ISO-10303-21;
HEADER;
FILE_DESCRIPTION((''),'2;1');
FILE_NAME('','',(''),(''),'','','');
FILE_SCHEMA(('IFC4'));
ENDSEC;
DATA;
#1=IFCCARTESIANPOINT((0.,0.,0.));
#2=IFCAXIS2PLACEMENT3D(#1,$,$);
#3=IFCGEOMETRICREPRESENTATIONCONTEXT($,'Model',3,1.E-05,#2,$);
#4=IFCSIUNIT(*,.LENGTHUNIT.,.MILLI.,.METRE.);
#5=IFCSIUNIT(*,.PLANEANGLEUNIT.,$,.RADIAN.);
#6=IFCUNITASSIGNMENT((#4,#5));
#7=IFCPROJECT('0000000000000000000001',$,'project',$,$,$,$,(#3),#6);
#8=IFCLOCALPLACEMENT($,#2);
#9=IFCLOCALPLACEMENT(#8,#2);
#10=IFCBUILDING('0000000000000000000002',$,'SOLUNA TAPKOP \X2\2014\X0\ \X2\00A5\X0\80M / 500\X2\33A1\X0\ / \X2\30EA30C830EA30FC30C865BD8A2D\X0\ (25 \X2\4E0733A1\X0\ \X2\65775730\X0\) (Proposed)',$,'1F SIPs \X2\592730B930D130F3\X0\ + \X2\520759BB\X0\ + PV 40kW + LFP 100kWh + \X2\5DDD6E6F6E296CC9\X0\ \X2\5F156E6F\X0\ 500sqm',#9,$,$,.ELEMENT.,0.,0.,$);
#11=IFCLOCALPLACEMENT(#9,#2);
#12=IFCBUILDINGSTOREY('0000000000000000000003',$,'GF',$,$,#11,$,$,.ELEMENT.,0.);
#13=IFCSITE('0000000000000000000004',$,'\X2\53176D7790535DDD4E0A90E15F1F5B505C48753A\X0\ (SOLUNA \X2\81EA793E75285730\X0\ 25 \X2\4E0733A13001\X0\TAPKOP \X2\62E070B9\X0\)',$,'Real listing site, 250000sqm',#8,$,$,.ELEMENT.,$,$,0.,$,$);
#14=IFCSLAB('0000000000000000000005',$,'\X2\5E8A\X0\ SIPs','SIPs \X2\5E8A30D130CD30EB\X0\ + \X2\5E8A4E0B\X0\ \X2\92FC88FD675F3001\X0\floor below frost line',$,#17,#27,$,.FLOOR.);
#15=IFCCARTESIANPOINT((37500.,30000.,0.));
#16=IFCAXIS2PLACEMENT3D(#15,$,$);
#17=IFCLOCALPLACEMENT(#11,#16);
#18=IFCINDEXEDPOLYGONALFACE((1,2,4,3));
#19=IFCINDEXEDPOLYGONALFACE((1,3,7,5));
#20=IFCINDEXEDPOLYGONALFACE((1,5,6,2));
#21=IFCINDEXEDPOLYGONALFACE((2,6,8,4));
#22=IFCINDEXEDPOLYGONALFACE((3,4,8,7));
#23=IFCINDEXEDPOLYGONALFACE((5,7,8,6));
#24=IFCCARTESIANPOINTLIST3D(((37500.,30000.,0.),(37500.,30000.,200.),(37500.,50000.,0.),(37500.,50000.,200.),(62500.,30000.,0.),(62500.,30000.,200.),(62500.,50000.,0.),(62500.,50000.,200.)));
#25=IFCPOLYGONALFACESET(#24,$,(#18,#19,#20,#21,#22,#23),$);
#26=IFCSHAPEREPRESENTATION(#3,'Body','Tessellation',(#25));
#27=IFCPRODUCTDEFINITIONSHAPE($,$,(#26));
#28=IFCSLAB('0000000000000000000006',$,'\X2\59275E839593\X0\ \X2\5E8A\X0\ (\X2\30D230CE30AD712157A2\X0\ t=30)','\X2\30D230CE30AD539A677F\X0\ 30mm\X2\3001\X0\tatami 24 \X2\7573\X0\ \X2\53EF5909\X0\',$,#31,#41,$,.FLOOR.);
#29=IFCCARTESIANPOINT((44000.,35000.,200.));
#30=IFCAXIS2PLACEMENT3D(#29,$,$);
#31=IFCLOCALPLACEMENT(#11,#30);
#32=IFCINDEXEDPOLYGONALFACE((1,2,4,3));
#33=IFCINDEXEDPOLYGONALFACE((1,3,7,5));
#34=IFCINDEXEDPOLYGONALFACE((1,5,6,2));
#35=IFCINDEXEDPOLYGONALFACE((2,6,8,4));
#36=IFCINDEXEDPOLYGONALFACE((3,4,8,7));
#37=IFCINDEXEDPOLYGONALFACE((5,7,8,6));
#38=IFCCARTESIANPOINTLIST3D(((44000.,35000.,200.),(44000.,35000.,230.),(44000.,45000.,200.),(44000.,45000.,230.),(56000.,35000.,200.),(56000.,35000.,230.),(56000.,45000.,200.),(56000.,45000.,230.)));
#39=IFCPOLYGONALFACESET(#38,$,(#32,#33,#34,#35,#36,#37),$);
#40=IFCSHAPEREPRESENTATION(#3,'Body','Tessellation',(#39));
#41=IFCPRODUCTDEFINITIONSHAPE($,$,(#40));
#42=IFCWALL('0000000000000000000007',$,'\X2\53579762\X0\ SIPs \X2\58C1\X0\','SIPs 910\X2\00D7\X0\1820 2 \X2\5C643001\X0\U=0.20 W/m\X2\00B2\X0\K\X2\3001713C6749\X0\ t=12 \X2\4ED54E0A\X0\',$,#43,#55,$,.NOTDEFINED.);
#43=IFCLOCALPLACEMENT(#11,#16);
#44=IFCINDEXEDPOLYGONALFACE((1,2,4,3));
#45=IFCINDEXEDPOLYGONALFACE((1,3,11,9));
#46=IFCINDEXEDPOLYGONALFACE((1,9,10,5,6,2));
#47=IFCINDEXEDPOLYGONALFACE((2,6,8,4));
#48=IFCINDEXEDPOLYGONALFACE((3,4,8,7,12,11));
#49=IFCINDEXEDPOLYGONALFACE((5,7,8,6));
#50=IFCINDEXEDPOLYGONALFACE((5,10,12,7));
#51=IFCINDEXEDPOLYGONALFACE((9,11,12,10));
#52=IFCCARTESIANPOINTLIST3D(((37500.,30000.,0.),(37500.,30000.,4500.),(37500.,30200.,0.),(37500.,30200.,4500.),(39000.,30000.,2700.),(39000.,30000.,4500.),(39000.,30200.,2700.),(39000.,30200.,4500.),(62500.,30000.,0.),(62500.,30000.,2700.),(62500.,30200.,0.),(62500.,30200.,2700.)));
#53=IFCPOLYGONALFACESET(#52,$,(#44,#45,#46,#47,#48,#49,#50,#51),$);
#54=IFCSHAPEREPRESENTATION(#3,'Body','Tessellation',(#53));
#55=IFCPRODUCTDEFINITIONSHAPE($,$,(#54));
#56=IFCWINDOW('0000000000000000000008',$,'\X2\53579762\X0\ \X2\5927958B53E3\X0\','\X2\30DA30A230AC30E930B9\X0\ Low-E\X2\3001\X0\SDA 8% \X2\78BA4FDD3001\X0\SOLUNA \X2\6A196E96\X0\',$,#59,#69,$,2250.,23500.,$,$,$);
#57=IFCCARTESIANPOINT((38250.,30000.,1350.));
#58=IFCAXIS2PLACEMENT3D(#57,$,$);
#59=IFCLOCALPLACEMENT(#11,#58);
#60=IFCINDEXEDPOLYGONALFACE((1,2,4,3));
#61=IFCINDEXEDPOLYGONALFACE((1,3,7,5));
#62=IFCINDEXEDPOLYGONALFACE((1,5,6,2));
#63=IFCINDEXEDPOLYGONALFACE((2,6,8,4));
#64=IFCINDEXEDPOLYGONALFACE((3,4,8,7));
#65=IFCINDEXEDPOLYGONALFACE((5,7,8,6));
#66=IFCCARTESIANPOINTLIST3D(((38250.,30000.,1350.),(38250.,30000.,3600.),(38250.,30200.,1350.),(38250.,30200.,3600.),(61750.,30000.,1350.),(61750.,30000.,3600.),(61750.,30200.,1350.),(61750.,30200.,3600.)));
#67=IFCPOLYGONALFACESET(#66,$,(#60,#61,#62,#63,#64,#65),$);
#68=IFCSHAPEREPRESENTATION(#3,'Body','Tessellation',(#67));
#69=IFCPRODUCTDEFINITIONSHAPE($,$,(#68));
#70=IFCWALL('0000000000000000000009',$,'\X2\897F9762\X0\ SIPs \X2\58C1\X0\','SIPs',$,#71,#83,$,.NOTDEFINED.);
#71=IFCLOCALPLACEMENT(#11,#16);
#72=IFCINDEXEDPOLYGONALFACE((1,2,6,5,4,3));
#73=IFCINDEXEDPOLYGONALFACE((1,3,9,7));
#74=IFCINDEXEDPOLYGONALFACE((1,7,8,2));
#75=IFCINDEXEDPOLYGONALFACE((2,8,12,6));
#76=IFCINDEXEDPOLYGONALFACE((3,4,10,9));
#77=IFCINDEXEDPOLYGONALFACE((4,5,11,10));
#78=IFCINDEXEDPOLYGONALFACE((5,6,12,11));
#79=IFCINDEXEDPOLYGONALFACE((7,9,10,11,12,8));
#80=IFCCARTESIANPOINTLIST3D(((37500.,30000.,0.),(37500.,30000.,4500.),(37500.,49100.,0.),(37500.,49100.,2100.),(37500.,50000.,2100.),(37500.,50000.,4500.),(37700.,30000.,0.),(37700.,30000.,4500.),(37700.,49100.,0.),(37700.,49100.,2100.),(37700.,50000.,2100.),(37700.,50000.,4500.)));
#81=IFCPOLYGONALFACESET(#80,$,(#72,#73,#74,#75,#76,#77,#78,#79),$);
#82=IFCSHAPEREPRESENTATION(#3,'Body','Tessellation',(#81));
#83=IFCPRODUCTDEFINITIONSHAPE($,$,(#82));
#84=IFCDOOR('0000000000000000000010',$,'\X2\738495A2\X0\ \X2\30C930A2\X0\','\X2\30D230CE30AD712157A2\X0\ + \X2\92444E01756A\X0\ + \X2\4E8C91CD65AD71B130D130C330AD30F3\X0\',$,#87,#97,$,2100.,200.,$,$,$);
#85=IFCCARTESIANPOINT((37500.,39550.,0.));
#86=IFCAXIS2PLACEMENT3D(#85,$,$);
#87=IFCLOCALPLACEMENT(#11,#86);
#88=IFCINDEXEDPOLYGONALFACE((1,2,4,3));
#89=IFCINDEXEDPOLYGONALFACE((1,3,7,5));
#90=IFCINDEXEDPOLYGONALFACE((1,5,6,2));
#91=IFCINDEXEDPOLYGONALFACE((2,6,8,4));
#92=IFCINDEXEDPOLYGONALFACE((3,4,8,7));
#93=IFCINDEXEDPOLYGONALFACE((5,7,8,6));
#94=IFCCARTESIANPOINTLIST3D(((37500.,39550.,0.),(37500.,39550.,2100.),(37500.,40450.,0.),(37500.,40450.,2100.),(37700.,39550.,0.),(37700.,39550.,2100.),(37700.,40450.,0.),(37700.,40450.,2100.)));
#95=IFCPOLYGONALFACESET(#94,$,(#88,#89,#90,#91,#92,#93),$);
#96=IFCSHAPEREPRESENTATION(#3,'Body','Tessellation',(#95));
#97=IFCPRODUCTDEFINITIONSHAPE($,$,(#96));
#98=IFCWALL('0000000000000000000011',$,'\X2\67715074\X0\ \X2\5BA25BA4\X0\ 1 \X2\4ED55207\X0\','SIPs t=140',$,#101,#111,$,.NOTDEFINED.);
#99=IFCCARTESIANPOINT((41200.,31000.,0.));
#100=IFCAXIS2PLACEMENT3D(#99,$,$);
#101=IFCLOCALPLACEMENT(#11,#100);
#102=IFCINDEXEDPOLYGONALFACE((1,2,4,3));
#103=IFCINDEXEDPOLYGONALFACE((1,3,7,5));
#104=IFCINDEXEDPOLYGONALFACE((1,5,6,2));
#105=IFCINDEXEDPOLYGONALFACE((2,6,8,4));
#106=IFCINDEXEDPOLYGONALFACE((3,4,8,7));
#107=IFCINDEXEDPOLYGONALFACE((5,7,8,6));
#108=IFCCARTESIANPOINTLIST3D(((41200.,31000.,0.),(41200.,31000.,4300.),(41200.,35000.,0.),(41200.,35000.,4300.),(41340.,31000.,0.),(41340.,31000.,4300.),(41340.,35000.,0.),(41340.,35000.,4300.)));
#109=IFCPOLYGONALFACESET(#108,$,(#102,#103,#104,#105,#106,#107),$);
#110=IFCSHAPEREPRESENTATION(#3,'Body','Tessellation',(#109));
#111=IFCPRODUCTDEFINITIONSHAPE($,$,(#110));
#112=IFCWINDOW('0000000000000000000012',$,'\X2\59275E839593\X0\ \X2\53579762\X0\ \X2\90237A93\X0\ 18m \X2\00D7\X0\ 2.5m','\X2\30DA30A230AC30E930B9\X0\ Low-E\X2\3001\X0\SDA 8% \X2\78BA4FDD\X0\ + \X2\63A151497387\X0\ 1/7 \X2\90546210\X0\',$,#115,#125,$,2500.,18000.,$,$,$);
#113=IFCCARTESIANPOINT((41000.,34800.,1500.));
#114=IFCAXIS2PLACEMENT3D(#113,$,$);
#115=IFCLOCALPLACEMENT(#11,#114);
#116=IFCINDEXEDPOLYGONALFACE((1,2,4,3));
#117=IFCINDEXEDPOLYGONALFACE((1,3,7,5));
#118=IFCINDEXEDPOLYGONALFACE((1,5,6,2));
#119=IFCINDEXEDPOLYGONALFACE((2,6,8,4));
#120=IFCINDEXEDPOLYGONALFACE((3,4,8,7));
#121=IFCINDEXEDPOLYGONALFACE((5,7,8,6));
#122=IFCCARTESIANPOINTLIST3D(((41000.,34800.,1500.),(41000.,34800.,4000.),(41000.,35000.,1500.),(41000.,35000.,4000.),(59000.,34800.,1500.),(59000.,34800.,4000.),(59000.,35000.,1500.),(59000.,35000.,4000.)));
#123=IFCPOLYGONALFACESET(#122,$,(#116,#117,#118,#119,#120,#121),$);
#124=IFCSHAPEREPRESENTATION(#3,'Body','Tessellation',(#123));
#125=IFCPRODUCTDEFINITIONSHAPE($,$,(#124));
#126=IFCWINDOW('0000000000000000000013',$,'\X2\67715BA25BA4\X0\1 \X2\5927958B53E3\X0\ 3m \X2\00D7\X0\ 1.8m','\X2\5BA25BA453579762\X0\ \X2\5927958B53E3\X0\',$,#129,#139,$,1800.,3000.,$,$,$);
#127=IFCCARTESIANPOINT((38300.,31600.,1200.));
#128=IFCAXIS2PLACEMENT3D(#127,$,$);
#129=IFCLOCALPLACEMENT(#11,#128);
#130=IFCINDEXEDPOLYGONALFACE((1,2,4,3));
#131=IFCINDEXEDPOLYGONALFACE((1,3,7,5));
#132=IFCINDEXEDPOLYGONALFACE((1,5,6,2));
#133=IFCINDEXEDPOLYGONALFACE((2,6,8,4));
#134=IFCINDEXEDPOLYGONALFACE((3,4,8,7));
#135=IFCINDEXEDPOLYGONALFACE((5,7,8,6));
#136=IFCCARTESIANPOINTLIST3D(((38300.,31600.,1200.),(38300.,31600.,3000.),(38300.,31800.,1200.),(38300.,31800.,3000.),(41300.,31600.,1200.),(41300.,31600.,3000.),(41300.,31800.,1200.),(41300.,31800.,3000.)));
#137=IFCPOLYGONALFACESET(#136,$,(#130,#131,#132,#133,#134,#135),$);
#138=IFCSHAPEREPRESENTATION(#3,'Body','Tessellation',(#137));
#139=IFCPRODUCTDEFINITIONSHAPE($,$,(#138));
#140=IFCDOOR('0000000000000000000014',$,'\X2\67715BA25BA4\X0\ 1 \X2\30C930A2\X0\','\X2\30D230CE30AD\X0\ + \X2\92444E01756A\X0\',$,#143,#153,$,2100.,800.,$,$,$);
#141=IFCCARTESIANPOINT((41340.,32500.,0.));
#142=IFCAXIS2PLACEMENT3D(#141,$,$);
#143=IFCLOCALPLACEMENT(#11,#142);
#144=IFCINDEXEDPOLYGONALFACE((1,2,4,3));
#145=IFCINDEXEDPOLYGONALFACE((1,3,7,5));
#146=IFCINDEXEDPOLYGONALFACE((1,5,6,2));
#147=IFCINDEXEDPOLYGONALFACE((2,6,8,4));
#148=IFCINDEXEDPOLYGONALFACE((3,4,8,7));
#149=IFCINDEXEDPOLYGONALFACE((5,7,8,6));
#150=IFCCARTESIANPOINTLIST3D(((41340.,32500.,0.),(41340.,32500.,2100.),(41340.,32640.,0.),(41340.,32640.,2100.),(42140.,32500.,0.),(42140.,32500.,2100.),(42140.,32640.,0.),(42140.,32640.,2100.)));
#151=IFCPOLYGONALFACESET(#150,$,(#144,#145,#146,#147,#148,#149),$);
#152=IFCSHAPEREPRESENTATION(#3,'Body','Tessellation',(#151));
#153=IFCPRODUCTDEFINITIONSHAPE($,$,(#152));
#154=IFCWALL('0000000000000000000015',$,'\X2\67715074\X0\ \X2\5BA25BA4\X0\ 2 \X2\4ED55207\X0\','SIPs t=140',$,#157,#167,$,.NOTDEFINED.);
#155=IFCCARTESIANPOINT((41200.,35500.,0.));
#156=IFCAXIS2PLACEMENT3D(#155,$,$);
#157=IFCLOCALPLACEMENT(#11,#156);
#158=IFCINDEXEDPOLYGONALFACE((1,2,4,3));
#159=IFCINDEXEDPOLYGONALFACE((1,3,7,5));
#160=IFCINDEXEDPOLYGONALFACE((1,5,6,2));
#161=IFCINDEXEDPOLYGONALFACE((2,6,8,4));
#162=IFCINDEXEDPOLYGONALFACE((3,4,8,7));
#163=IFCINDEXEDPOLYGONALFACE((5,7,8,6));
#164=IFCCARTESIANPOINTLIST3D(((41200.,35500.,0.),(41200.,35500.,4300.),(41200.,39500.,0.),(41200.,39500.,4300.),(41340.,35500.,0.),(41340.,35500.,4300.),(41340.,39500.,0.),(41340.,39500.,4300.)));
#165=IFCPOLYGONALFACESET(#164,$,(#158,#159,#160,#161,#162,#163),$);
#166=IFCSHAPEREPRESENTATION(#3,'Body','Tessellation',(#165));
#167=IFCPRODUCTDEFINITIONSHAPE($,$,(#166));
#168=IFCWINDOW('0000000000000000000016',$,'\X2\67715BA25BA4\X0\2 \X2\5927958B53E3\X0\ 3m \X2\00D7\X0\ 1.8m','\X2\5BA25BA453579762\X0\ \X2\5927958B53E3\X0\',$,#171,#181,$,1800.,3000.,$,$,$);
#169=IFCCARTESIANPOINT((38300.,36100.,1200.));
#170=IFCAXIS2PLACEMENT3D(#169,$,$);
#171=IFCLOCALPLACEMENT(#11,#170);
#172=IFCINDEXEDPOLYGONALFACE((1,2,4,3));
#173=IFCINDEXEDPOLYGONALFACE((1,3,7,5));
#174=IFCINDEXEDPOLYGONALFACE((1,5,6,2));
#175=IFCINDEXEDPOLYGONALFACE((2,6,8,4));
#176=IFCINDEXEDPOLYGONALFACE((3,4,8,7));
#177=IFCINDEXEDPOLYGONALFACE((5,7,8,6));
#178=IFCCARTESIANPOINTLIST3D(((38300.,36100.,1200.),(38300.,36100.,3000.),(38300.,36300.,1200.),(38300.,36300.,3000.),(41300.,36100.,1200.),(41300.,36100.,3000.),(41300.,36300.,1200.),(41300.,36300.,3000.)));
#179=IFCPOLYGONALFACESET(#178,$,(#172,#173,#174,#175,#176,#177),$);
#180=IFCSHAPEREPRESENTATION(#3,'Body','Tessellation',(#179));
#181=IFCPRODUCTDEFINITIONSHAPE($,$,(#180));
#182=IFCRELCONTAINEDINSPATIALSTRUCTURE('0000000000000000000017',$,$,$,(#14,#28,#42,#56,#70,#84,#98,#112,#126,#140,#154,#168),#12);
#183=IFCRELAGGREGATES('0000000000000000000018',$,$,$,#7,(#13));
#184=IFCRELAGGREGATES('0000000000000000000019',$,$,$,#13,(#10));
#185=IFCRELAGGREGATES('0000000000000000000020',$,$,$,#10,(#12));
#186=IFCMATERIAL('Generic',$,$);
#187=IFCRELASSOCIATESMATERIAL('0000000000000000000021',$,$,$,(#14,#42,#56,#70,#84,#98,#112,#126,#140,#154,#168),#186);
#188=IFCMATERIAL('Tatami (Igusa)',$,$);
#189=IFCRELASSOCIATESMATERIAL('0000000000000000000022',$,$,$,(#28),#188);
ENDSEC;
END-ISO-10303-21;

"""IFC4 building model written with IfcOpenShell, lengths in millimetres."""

from ifc_helpers import new_model, si_unit, frame, frame_2d, origin, place, context, project, spatial, rectangle, extrude, material, element, fill, save


model = new_model("IFC4")

# Units and contexts
model_context = context("Model", 3, precision=1e-05, world=origin())
ifc_project = project(units=[si_unit("LENGTHUNIT", "METRE", prefix="MILLI"), si_unit("PLANEANGLEUNIT", "RADIAN")], contexts=[model_context])

# Site, building, storey
site_placement = place(None, origin())
site = spatial("IfcSite", under=ifc_project, at=site_placement, Name="北海道川上郡弟子屈町 (SOLUNA 自社用地 25 万㎡、TAPKOP 拠点)", ObjectType="Real listing site, 250000sqm", CompositionType="ELEMENT", RefElevation=0.0)
building_placement = place(site_placement, origin())
building = spatial("IfcBuilding", under=site, at=building_placement, Name="SOLUNA TAPKOP — ¥80M / 500㎡ / リトリート施設 (25 万㎡ 敷地) (Proposed)", ObjectType="1F SIPs 大スパン + 切妻 + PV 40kW + LFP 100kWh + 川湯温泉 引湯 500sqm", CompositionType="ELEMENT", ElevationOfRefHeight=0.0, ElevationOfTerrain=0.0)
storey_placement = place(building_placement, origin())
storey = spatial("IfcBuildingStorey", under=building, at=storey_placement, Name="GF", CompositionType="ELEMENT", Elevation=0.0)

# Slabs
ifc_material_1 = material(Name="Generic")
slab_1_placement = place(storey_placement, frame((37500.0, 30000.0, 0.0)))
element("IfcSlab", 1, at=slab_1_placement, inside=storey, material=ifc_material_1, Name="床 SIPs", Description="SIPs 床パネル + 床下 鋼製束、floor below frost line", PredefinedType="FLOOR", context=model_context, shape_type="SweptSolid", body=[
    extrude(rectangle(XDim=25000.0, YDim=20000.0, at=frame_2d((12500.0, 10000.0))), frame((37500.0, 30000.0, 0.0)), (0.0, 0.0, 1.0), 200.0),
])
ifc_material_2 = material(Name="Tatami (Igusa)")
slab_2_placement = place(storey_placement, frame((44000.0, 35000.0, 200.0)))
element("IfcSlab", 2, at=slab_2_placement, inside=storey, material=ifc_material_2, Name="大広間 床 (ヒノキ無垢 t=30)", Description="ヒノキ厚板 30mm、tatami 24 畳 可変", PredefinedType="FLOOR", context=model_context, shape_type="SweptSolid", body=[
    extrude(rectangle(XDim=12000.0, YDim=10000.0, at=frame_2d((6000.0, 5000.0))), frame((44000.0, 35000.0, 200.0)), (0.0, 0.0, 1.0), 30.0),
])

# Wall, opening, window
wall_1_placement = place(storey_placement, frame((37500.0, 30000.0, 0.0)))
wall_1 = element("IfcWall", 3, at=wall_1_placement, inside=storey, material=ifc_material_1, Name="南面 SIPs 壁", Description="SIPs 910×1820 2 層、U=0.20 W/m²K、焼杉 t=12 仕上", PredefinedType="NOTDEFINED", context=model_context, shape_type="SweptSolid", body=[
    extrude(rectangle(XDim=25000.0, YDim=200.0, at=frame_2d((12500.0, 100.0))), frame((37500.0, 30000.0, 0.0)), (0.0, 0.0, 1.0), 4500.0),
])
opening_1_placement = place(storey_placement, frame((38250.0, 30000.0, 1350.0)))
opening_1 = element("IfcOpeningElement", 4, at=opening_1_placement, cuts=wall_1, PredefinedType="NOTDEFINED", context=model_context, shape_type="SweptSolid", body=[
    extrude(rectangle(XDim=23500.0, YDim=200.0, at=frame_2d((11750.0, 100.0))), frame((38250.0, 30000.0, 1350.0)), (0.0, 0.0, 1.0), 2250.0),
])
window_1_placement = place(storey_placement, frame((38250.0, 30000.0, 1350.0)))
window_1 = element("IfcWindow", 5, at=window_1_placement, inside=storey, material=ifc_material_1, Name="南面 大開口", Description="ペアガラス Low-E、SDA 8% 確保、SOLUNA 標準", OverallHeight=2250.0, OverallWidth=23500.0, context=model_context, shape_type="SweptSolid", body=[
    extrude(rectangle(XDim=23500.0, YDim=200.0, at=frame_2d((11750.0, 100.0))), frame((38250.0, 30000.0, 1350.0)), (0.0, 0.0, 1.0), 2250.0),
])
fill(opening_1, window_1)

# Wall, opening, door
wall_2_placement = place(storey_placement, frame((37500.0, 30000.0, 0.0)))
wall_2 = element("IfcWall", 6, at=wall_2_placement, inside=storey, material=ifc_material_1, Name="西面 SIPs 壁", Description="SIPs", PredefinedType="NOTDEFINED", context=model_context, shape_type="SweptSolid", body=[
    extrude(rectangle(XDim=200.0, YDim=20000.0, at=frame_2d((100.0, 10000.0))), frame((37500.0, 30000.0, 0.0)), (0.0, 0.0, 1.0), 4500.0),
])
opening_2_placement = place(storey_placement, frame((37500.0, 39550.0, 0.0)))
opening_2 = element("IfcOpeningElement", 7, at=opening_2_placement, cuts=wall_2, PredefinedType="NOTDEFINED", context=model_context, shape_type="SweptSolid", body=[
    extrude(rectangle(XDim=200.0, YDim=900.0, at=frame_2d((100.0, 450.0))), frame((37500.0, 39550.0, 0.0)), (0.0, 0.0, 1.0), 2100.0),
])
door_1_placement = place(storey_placement, frame((37500.0, 39550.0, 0.0)))
door_1 = element("IfcDoor", 8, at=door_1_placement, inside=storey, material=ifc_material_1, Name="玄関 ドア", Description="ヒノキ無垢 + 鉄丁番 + 二重断熱パッキン", OverallHeight=2100.0, OverallWidth=200.0, context=model_context, shape_type="SweptSolid", body=[
    extrude(rectangle(XDim=200.0, YDim=900.0, at=frame_2d((100.0, 450.0))), frame((37500.0, 39550.0, 0.0)), (0.0, 0.0, 1.0), 2100.0),
])
fill(opening_2, door_1)

# Wall, openings, windows
wall_3_placement = place(storey_placement, frame((41200.0, 31000.0, 0.0)))
wall_3 = element("IfcWall", 9, at=wall_3_placement, inside=storey, material=ifc_material_1, Name="東側 客室 1 仕切", Description="SIPs t=140", PredefinedType="NOTDEFINED", context=model_context, shape_type="SweptSolid", body=[
    extrude(rectangle(XDim=140.0, YDim=4000.0, at=frame_2d((70.0, 2000.0))), frame((41200.0, 31000.0, 0.0)), (0.0, 0.0, 1.0), 4300.0),
])
opening_3_placement = place(storey_placement, frame((41000.0, 34800.0, 1500.0)))
opening_3 = element("IfcOpeningElement", 10, at=opening_3_placement, cuts=wall_3, PredefinedType="NOTDEFINED", context=model_context, shape_type="SweptSolid", body=[
    extrude(rectangle(XDim=18000.0, YDim=200.0, at=frame_2d((9000.0, 100.0))), frame((41000.0, 34800.0, 1500.0)), (0.0, 0.0, 1.0), 2500.0),
])
opening_4_placement = place(storey_placement, frame((38300.0, 31600.0, 1200.0)))
opening_4 = element("IfcOpeningElement", 11, at=opening_4_placement, cuts=wall_3, PredefinedType="NOTDEFINED", context=model_context, shape_type="SweptSolid", body=[
    extrude(rectangle(XDim=3000.0, YDim=200.0, at=frame_2d((1500.0, 100.0))), frame((38300.0, 31600.0, 1200.0)), (0.0, 0.0, 1.0), 1800.0),
])
window_2_placement = place(storey_placement, frame((41000.0, 34800.0, 1500.0)))
window_2 = element("IfcWindow", 12, at=window_2_placement, inside=storey, material=ifc_material_1, Name="大広間 南面 連窓 18m × 2.5m", Description="ペアガラス Low-E、SDA 8% 確保 + 採光率 1/7 達成", OverallHeight=2500.0, OverallWidth=18000.0, context=model_context, shape_type="SweptSolid", body=[
    extrude(rectangle(XDim=18000.0, YDim=200.0, at=frame_2d((9000.0, 100.0))), frame((41000.0, 34800.0, 1500.0)), (0.0, 0.0, 1.0), 2500.0),
])
fill(opening_3, window_2)
window_3_placement = place(storey_placement, frame((38300.0, 31600.0, 1200.0)))
window_3 = element("IfcWindow", 13, at=window_3_placement, inside=storey, material=ifc_material_1, Name="東客室1 大開口 3m × 1.8m", Description="客室南面 大開口", OverallHeight=1800.0, OverallWidth=3000.0, context=model_context, shape_type="SweptSolid", body=[
    extrude(rectangle(XDim=3000.0, YDim=200.0, at=frame_2d((1500.0, 100.0))), frame((38300.0, 31600.0, 1200.0)), (0.0, 0.0, 1.0), 1800.0),
])
fill(opening_4, window_3)

# Door
door_2_placement = place(storey_placement, frame((41340.0, 32500.0, 0.0)))
element("IfcDoor", 14, at=door_2_placement, inside=storey, material=ifc_material_1, Name="東客室 1 ドア", Description="ヒノキ + 鉄丁番", OverallHeight=2100.0, OverallWidth=800.0, context=model_context, shape_type="SweptSolid", body=[
    extrude(rectangle(XDim=800.0, YDim=140.0, at=frame_2d((400.0, 70.0))), frame((41340.0, 32500.0, 0.0)), (0.0, 0.0, 1.0), 2100.0),
])

# Wall, opening, window
wall_4_placement = place(storey_placement, frame((41200.0, 35500.0, 0.0)))
wall_4 = element("IfcWall", 15, at=wall_4_placement, inside=storey, material=ifc_material_1, Name="東側 客室 2 仕切", Description="SIPs t=140", PredefinedType="NOTDEFINED", context=model_context, shape_type="SweptSolid", body=[
    extrude(rectangle(XDim=140.0, YDim=4000.0, at=frame_2d((70.0, 2000.0))), frame((41200.0, 35500.0, 0.0)), (0.0, 0.0, 1.0), 4300.0),
])
opening_5_placement = place(storey_placement, frame((38300.0, 36100.0, 1200.0)))
opening_5 = element("IfcOpeningElement", 16, at=opening_5_placement, cuts=wall_4, PredefinedType="NOTDEFINED", context=model_context, shape_type="SweptSolid", body=[
    extrude(rectangle(XDim=3000.0, YDim=200.0, at=frame_2d((1500.0, 100.0))), frame((38300.0, 36100.0, 1200.0)), (0.0, 0.0, 1.0), 1800.0),
])
window_4_placement = place(storey_placement, frame((38300.0, 36100.0, 1200.0)))
window_4 = element("IfcWindow", 17, at=window_4_placement, inside=storey, material=ifc_material_1, Name="東客室2 大開口 3m × 1.8m", Description="客室南面 大開口", OverallHeight=1800.0, OverallWidth=3000.0, context=model_context, shape_type="SweptSolid", body=[
    extrude(rectangle(XDim=3000.0, YDim=200.0, at=frame_2d((1500.0, 100.0))), frame((38300.0, 36100.0, 1200.0)), (0.0, 0.0, 1.0), 1800.0),
])
fill(opening_5, window_4)

save(model, "model.ifc")
